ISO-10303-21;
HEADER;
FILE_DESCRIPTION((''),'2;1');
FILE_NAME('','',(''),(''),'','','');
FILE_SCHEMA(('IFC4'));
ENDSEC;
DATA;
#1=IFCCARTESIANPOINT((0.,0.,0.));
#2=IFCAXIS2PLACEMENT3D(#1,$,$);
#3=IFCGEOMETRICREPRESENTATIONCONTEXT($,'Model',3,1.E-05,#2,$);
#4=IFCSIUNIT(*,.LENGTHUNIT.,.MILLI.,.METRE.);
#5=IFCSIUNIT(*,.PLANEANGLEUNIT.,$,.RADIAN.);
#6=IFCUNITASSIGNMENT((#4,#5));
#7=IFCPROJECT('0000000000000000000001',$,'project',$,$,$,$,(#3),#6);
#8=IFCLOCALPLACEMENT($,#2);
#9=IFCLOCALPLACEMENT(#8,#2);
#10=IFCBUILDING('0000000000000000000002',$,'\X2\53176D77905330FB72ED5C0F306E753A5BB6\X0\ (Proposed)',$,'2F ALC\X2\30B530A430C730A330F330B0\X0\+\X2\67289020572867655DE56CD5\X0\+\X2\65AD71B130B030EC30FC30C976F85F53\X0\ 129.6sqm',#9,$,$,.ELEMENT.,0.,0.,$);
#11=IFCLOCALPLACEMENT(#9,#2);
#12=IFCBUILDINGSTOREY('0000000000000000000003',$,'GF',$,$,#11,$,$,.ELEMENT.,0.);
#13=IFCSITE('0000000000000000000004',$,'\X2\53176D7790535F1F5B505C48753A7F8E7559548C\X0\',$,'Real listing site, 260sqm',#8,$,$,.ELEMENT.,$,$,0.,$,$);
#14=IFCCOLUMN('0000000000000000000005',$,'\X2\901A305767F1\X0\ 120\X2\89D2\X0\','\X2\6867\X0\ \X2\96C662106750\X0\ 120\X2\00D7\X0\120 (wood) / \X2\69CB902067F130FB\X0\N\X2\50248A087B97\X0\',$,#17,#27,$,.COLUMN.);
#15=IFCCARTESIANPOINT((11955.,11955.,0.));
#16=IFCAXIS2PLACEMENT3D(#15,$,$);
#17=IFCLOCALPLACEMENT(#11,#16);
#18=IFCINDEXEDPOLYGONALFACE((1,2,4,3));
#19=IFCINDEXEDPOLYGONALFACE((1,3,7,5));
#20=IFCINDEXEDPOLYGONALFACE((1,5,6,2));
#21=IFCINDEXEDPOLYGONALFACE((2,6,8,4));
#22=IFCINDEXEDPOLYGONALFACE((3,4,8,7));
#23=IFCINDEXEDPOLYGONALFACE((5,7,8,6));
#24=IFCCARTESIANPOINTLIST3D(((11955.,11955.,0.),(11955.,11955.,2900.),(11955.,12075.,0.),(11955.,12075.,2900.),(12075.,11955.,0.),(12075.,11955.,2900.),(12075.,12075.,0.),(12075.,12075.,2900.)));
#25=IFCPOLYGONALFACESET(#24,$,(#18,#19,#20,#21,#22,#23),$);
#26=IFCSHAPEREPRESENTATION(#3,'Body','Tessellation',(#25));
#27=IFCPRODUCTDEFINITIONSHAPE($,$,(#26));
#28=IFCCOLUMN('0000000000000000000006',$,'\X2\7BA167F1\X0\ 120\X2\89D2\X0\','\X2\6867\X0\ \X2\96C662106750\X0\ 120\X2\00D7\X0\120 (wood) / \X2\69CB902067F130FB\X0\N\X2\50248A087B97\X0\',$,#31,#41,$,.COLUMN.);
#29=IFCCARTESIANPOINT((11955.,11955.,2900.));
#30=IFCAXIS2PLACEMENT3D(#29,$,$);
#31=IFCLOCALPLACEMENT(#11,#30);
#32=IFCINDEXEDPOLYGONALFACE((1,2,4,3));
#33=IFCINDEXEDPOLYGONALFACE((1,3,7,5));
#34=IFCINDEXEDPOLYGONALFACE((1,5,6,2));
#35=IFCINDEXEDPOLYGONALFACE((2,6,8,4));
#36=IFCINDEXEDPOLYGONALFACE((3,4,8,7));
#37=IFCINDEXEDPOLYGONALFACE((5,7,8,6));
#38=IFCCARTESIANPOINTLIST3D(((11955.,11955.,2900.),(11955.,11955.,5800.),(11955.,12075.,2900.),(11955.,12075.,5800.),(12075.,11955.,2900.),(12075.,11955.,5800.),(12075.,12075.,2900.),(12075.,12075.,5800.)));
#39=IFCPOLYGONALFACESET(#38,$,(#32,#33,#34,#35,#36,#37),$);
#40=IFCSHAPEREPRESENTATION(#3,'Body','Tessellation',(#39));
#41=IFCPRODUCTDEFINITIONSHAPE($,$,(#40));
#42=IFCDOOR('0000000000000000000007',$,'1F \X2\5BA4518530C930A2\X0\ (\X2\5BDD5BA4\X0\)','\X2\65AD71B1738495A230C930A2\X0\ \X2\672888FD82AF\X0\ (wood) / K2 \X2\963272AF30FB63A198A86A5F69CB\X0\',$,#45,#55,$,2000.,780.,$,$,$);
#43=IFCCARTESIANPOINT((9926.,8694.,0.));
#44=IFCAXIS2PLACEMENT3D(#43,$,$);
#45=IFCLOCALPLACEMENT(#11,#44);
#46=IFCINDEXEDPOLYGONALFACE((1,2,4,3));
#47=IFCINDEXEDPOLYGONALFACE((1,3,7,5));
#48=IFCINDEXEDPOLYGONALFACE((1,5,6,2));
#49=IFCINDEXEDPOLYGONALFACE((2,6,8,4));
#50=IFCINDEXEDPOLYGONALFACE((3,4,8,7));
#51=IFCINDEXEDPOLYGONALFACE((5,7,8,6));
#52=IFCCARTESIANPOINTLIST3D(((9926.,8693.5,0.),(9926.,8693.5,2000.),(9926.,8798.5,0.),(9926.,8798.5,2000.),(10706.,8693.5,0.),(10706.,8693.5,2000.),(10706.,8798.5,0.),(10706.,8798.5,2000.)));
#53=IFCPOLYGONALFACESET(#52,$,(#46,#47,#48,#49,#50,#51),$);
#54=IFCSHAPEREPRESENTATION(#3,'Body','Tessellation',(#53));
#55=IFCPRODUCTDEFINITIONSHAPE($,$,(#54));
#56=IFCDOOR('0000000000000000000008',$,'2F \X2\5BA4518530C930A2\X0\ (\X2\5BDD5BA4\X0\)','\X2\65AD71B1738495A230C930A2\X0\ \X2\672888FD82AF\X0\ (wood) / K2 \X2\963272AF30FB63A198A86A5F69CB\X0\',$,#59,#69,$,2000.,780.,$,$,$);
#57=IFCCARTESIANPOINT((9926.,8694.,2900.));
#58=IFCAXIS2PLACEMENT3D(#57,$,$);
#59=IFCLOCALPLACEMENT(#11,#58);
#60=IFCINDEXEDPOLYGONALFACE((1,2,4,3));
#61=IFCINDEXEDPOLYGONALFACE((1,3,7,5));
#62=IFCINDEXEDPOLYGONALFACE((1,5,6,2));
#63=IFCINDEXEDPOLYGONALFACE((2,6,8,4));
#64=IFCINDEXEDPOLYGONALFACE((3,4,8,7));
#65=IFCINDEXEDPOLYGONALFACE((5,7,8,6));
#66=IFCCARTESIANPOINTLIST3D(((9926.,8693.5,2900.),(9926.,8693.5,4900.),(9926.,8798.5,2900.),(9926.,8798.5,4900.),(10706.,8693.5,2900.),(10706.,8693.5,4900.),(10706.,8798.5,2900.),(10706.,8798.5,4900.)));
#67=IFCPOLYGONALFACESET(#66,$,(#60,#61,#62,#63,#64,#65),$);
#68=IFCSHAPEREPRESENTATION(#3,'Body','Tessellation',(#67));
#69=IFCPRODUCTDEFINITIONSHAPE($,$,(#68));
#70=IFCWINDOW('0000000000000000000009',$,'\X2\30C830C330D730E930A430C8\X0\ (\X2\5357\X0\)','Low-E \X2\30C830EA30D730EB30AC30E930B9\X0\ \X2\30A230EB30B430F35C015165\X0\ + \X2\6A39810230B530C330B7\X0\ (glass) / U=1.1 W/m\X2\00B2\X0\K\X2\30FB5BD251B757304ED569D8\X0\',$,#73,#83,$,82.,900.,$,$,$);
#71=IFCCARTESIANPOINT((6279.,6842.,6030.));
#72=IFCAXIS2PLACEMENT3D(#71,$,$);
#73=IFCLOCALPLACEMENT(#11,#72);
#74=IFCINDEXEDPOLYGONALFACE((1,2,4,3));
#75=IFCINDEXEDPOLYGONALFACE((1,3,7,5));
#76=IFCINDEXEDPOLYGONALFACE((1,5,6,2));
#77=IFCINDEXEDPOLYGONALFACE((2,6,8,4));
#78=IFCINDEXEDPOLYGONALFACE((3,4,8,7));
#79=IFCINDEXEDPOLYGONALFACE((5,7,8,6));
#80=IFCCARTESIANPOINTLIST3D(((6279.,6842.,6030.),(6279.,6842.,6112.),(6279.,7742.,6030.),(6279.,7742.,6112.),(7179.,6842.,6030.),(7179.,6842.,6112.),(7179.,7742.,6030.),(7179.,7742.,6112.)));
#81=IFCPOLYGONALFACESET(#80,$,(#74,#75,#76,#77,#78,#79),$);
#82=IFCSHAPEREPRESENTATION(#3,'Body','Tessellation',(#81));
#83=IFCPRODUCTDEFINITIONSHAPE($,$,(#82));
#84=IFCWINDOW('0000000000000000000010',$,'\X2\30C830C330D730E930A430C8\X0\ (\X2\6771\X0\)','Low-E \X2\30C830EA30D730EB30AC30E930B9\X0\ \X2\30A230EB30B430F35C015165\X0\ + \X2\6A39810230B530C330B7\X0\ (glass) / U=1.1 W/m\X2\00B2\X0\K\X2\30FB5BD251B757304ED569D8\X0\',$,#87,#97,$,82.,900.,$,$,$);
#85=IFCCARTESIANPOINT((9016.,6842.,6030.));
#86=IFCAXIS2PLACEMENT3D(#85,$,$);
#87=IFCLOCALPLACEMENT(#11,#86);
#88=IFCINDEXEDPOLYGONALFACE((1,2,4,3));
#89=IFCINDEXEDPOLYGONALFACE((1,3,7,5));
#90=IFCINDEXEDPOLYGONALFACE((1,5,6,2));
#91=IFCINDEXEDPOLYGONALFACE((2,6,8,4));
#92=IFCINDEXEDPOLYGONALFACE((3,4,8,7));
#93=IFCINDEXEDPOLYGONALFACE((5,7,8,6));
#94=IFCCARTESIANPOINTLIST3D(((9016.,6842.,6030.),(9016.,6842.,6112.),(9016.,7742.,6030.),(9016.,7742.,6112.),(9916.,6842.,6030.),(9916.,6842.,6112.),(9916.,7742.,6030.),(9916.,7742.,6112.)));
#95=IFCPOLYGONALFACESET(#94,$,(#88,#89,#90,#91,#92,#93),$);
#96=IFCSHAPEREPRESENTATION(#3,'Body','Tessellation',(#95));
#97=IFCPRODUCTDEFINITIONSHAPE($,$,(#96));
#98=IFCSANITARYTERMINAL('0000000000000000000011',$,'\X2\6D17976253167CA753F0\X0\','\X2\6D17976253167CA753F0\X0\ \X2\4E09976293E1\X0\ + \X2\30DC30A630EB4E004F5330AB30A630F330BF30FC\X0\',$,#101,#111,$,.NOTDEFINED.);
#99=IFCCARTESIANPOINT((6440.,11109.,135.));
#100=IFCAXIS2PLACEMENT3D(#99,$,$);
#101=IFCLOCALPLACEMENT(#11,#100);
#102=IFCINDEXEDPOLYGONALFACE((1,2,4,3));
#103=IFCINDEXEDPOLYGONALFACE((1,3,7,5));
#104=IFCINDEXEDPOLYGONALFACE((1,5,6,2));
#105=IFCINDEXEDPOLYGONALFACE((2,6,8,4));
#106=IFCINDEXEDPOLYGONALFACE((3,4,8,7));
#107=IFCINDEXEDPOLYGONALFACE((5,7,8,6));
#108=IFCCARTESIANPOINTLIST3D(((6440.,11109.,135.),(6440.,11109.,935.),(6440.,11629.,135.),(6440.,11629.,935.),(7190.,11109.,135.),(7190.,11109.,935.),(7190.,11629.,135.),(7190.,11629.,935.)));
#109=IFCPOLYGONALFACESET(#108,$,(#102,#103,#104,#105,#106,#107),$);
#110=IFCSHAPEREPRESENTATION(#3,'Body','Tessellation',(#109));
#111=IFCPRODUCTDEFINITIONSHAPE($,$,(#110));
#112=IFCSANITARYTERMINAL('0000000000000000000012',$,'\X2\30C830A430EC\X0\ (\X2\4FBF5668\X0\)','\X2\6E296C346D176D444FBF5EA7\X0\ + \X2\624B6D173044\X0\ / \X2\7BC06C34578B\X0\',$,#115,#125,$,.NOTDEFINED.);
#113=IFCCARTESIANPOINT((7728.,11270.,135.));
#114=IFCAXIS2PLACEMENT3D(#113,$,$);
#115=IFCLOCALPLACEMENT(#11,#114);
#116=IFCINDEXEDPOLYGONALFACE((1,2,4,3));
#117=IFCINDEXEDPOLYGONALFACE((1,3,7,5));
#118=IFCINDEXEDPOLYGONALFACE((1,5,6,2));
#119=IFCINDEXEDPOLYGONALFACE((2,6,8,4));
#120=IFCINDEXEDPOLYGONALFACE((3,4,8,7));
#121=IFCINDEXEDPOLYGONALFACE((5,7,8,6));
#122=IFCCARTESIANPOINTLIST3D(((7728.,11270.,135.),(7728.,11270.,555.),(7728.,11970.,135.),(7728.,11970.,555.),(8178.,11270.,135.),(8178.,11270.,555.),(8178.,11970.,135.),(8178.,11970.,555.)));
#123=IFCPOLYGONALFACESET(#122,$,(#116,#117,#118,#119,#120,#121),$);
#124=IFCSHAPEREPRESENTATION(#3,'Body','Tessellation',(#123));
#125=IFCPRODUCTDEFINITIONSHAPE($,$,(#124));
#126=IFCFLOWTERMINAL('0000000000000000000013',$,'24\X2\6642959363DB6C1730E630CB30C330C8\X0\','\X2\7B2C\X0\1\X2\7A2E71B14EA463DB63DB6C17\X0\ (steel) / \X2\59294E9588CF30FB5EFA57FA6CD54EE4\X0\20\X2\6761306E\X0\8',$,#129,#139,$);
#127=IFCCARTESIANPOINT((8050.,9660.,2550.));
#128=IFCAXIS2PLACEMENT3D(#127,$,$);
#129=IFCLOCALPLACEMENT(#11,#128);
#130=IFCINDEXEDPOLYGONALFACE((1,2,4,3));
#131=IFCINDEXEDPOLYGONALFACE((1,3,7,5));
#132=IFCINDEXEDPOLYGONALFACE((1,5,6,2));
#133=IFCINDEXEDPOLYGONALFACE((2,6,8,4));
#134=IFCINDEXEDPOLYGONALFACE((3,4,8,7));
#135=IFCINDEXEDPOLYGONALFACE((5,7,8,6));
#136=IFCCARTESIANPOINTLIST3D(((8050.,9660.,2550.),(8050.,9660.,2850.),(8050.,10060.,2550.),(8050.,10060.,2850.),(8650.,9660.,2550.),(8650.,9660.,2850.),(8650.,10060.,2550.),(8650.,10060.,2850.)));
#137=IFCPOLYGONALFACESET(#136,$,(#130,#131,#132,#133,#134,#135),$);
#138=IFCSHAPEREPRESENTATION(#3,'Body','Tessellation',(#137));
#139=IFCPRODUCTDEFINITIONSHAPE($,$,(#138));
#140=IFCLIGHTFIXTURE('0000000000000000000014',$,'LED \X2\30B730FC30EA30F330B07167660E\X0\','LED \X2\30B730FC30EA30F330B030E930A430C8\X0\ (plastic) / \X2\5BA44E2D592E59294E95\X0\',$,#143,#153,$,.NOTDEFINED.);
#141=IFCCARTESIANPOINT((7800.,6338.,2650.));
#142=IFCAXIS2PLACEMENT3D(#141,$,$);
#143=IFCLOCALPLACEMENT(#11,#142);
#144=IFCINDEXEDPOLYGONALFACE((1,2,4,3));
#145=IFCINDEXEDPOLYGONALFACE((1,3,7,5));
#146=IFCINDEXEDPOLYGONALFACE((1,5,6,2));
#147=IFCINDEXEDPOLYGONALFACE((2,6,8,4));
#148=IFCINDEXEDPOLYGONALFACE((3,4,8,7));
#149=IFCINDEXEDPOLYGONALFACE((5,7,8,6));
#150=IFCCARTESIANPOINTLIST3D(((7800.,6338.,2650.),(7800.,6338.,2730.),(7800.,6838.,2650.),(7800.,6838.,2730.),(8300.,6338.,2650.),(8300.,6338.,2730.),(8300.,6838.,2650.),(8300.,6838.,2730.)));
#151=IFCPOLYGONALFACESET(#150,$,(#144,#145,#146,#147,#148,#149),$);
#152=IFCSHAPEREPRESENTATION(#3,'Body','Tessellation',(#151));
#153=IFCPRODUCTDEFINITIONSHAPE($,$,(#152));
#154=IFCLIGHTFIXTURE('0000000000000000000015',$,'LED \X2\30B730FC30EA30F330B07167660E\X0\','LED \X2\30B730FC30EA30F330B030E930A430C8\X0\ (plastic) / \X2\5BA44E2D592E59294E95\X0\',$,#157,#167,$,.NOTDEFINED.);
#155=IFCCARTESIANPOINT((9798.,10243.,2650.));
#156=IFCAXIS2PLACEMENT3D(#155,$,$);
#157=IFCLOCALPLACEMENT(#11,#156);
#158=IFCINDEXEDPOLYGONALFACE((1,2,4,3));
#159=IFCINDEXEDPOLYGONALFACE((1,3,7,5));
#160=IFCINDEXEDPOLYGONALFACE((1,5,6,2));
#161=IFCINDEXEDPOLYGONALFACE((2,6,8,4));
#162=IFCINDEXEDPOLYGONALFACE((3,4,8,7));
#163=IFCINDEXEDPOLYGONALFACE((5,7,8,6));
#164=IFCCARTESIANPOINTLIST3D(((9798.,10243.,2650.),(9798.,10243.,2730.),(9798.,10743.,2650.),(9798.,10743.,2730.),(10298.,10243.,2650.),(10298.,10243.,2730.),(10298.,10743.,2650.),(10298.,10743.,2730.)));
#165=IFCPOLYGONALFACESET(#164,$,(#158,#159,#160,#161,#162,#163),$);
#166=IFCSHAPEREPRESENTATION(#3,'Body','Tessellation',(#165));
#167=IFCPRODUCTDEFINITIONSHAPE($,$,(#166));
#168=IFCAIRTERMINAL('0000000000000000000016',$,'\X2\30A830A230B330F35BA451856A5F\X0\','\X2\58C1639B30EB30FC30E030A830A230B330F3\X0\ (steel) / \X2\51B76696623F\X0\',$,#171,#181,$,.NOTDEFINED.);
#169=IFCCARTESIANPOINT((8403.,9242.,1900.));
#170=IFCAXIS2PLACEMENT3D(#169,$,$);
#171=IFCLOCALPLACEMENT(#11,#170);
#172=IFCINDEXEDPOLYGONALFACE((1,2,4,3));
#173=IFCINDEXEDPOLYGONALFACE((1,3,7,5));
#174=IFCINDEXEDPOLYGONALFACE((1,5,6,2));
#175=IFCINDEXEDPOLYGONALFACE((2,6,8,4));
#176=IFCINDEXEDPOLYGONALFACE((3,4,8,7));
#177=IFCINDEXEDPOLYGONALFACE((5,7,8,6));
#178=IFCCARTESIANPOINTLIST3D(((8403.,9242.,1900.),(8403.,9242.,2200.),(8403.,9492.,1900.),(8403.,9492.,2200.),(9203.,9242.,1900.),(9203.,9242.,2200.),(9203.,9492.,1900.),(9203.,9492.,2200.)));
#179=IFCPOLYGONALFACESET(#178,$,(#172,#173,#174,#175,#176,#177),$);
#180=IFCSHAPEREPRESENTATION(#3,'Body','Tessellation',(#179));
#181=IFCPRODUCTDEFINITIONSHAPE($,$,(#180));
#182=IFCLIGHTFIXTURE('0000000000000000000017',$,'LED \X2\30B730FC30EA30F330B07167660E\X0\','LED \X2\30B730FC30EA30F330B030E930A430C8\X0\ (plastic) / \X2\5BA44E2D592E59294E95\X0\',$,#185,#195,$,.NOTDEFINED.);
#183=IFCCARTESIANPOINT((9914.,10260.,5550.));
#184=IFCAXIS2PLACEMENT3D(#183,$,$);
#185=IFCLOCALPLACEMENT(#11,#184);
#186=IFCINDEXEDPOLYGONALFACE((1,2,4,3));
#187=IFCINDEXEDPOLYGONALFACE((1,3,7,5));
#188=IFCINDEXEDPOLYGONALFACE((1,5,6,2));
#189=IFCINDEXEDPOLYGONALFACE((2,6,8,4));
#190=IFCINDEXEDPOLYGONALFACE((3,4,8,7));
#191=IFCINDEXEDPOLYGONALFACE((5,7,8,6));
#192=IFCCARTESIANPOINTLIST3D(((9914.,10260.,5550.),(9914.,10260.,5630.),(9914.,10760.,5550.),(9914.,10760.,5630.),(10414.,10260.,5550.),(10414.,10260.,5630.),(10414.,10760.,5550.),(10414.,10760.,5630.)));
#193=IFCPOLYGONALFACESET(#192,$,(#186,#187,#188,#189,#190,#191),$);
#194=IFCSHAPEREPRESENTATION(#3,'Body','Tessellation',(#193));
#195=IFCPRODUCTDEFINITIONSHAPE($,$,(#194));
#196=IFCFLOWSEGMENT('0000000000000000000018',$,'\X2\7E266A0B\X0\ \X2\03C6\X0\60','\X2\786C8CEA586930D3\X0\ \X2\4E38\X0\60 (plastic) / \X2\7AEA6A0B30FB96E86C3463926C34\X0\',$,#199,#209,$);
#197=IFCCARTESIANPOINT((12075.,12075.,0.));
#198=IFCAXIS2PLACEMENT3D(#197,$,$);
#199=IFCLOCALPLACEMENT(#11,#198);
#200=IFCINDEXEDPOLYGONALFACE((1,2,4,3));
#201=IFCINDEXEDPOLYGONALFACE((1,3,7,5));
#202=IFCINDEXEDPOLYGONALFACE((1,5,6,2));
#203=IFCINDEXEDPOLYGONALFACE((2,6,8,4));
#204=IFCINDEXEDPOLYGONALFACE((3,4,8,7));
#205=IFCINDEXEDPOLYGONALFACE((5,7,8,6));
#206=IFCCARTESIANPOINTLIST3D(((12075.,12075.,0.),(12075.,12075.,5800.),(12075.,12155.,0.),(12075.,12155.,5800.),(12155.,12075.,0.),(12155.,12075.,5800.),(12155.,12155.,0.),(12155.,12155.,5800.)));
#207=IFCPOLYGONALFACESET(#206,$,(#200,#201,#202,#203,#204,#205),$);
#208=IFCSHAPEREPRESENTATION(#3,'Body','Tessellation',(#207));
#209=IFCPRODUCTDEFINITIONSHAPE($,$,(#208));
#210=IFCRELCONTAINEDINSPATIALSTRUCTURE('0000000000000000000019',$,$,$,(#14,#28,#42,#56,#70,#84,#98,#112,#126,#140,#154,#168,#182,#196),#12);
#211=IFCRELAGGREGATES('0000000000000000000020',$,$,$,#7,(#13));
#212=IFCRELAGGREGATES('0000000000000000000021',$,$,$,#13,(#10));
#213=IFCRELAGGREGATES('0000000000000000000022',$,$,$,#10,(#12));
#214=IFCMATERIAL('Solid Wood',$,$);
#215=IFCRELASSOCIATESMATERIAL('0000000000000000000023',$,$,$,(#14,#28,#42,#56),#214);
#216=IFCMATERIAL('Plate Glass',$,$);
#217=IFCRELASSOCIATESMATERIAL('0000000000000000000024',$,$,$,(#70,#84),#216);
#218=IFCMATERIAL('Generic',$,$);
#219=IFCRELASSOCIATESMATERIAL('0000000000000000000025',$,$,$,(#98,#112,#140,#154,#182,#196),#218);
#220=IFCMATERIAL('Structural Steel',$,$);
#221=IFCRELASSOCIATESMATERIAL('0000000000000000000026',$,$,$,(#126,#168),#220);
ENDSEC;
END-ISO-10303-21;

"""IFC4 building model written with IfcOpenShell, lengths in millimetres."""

from ifc_helpers import new_model, si_unit, frame, frame_2d, origin, place, context, project, spatial, rectangle, extrude, material, element, save


model = new_model("IFC4")

# Units and contexts
model_context = context("Model", 3, precision=1e-05, world=origin())
ifc_project = project(units=[si_unit("LENGTHUNIT", "METRE", prefix="MILLI"), si_unit("PLANEANGLEUNIT", "RADIAN")], contexts=[model_context])

# Site, building, storey
site_placement = place(None, origin())
site = spatial("IfcSite", under=ifc_project, at=site_placement, Name="北海道弟子屈町美留和", ObjectType="Real listing site, 260sqm", CompositionType="ELEMENT", RefElevation=0.0)
building_placement = place(site_placement, origin())
building = spatial("IfcBuilding", under=site, at=building_placement, Name="北海道・狭小の町家 (Proposed)", ObjectType="2F ALCサイディング+木造在来工法+断熱グレード相当 129.6sqm", CompositionType="ELEMENT", ElevationOfRefHeight=0.0, ElevationOfTerrain=0.0)
storey_placement = place(building_placement, origin())
storey = spatial("IfcBuildingStorey", under=building, at=storey_placement, Name="GF", CompositionType="ELEMENT", Elevation=0.0)

# Columns
ifc_material_1 = material(Name="Solid Wood")
column_1_placement = place(storey_placement, frame((11955.0, 11955.0, 0.0)))
element("IfcColumn", 1, at=column_1_placement, inside=storey, material=ifc_material_1, Name="通し柱 120角", Description="桧 集成材 120×120 (wood) / 構造柱・N値計算", PredefinedType="COLUMN", context=model_context, shape_type="SweptSolid", body=[
    extrude(rectangle(XDim=120.0, YDim=120.0, at=frame_2d((60.0, 60.0))), frame((11955.0, 11955.0, 0.0)), (0.0, 0.0, 1.0), 2900.0),
])
column_2_placement = place(storey_placement, frame((11955.0, 11955.0, 2900.0)))
element("IfcColumn", 2, at=column_2_placement, inside=storey, material=ifc_material_1, Name="管柱 120角", Description="桧 集成材 120×120 (wood) / 構造柱・N値計算", PredefinedType="COLUMN", context=model_context, shape_type="SweptSolid", body=[
    extrude(rectangle(XDim=120.0, YDim=120.0, at=frame_2d((60.0, 60.0))), frame((11955.0, 11955.0, 2900.0)), (0.0, 0.0, 1.0), 2900.0),
])

# Door
door_1_placement = place(storey_placement, frame((9926.0, 8694.0, 0.0)))
element("IfcDoor", 3, at=door_1_placement, inside=storey, material=ifc_material_1, Name="1F 室内ドア (寝室)", Description="断熱玄関ドア 木製芯 (wood) / K2 防犯・採風機構", OverallHeight=2000.0, OverallWidth=780.0, context=model_context, shape_type="SweptSolid", body=[
    extrude(rectangle(XDim=780.0, YDim=105.0, at=frame_2d((390.0, 52.0))), frame((9926.0, 8694.0, 0.0)), (0.0, 0.0, 1.0), 2000.0),
])

# Door
door_2_placement = place(storey_placement, frame((9926.0, 8694.0, 2900.0)))
element("IfcDoor", 4, at=door_2_placement, inside=storey, material=ifc_material_1, Name="2F 室内ドア (寝室)", Description="断熱玄関ドア 木製芯 (wood) / K2 防犯・採風機構", OverallHeight=2000.0, OverallWidth=780.0, context=model_context, shape_type="SweptSolid", body=[
    extrude(rectangle(XDim=780.0, YDim=105.0, at=frame_2d((390.0, 52.0))), frame((9926.0, 8694.0, 2900.0)), (0.0, 0.0, 1.0), 2000.0),
])

# Windows
ifc_material_2 = material(Name="Plate Glass")
window_1_placement = place(storey_placement, frame((6279.0, 6842.0, 6030.0)))
element("IfcWindow", 5, at=window_1_placement, inside=storey, material=ifc_material_2, Name="トップライト (南)", Description="Low-E トリプルガラス アルゴン封入 + 樹脂サッシ (glass) / U=1.1 W/m²K・寒冷地仕様", OverallHeight=82.0, OverallWidth=900.0, context=model_context, shape_type="SweptSolid", body=[
    extrude(rectangle(XDim=900.0, YDim=900.0, at=frame_2d((450.0, 450.0))), frame((6279.0, 6842.0, 6030.0)), (0.0, 0.0, 1.0), 82.0),
])
window_2_placement = place(storey_placement, frame((9016.0, 6842.0, 6030.0)))
element("IfcWindow", 6, at=window_2_placement, inside=storey, material=ifc_material_2, Name="トップライト (東)", Description="Low-E トリプルガラス アルゴン封入 + 樹脂サッシ (glass) / U=1.1 W/m²K・寒冷地仕様", OverallHeight=82.0, OverallWidth=900.0, context=model_context, shape_type="SweptSolid", body=[
    extrude(rectangle(XDim=900.0, YDim=900.0, at=frame_2d((450.0, 450.0))), frame((9016.0, 6842.0, 6030.0)), (0.0, 0.0, 1.0), 82.0),
])

# Sanitary terminals
ifc_material_3 = material(Name="Generic")
sanitary_terminal_1_placement = place(storey_placement, frame((6440.0, 11109.0, 135.0)))
element("IfcSanitaryTerminal", 7, at=sanitary_terminal_1_placement, inside=storey, material=ifc_material_3, Name="洗面化粧台", Description="洗面化粧台 三面鏡 + ボウル一体カウンター", PredefinedType="NOTDEFINED", context=model_context, shape_type="SweptSolid", body=[
    extrude(rectangle(XDim=750.0, YDim=520.0, at=frame_2d((375.0, 260.0))), frame((6440.0, 11109.0, 135.0)), (0.0, 0.0, 1.0), 800.0),
])
sanitary_terminal_2_placement = place(storey_placement, frame((7728.0, 11270.0, 135.0)))
element("IfcSanitaryTerminal", 8, at=sanitary_terminal_2_placement, inside=storey, material=ifc_material_3, Name="トイレ (便器)", Description="温水洗浄便座 + 手洗い / 節水型", PredefinedType="NOTDEFINED", context=model_context, shape_type="SweptSolid", body=[
    extrude(rectangle(XDim=450.0, YDim=700.0, at=frame_2d((225.0, 350.0))), frame((7728.0, 11270.0, 135.0)), (0.0, 0.0, 1.0), 420.0),
])

# Flow terminal
ifc_material_4 = material(Name="Structural Steel")
flow_terminal_placement = place(storey_placement, frame((8050.0, 9660.0, 2550.0)))
element("IfcFlowTerminal", 9, at=flow_terminal_placement, inside=storey, material=ifc_material_4, Name="24時間換気ユニット", Description="第1種熱交換換気 (steel) / 天井裏・建基法令20条の8", context=model_context, shape_type="SweptSolid", body=[
    extrude(rectangle(XDim=600.0, YDim=400.0, at=frame_2d((300.0, 200.0))), frame((8050.0, 9660.0, 2550.0)), (0.0, 0.0, 1.0), 300.0),
])

# Light fixtures
light_fixture_1_placement = place(storey_placement, frame((7800.0, 6338.0, 2650.0)))
element("IfcLightFixture", 10, at=light_fixture_1_placement, inside=storey, material=ifc_material_3, Name="LED シーリング照明", Description="LED シーリングライト (plastic) / 室中央天井", PredefinedType="NOTDEFINED", context=model_context, shape_type="SweptSolid", body=[
    extrude(rectangle(XDim=500.0, YDim=500.0, at=frame_2d((250.0, 250.0))), frame((7800.0, 6338.0, 2650.0)), (0.0, 0.0, 1.0), 80.0),
])
light_fixture_2_placement = place(storey_placement, frame((9798.0, 10243.0, 2650.0)))
element("IfcLightFixture", 11, at=light_fixture_2_placement, inside=storey, material=ifc_material_3, Name="LED シーリング照明", Description="LED シーリングライト (plastic) / 室中央天井", PredefinedType="NOTDEFINED", context=model_context, shape_type="SweptSolid", body=[
    extrude(rectangle(XDim=500.0, YDim=500.0, at=frame_2d((250.0, 250.0))), frame((9798.0, 10243.0, 2650.0)), (0.0, 0.0, 1.0), 80.0),
])

# Air terminal
air_terminal_placement = place(storey_placement, frame((8403.0, 9242.0, 1900.0)))
element("IfcAirTerminal", 12, at=air_terminal_placement, inside=storey, material=ifc_material_4, Name="エアコン室内機", Description="壁掛ルームエアコン (steel) / 冷暖房", PredefinedType="NOTDEFINED", context=model_context, shape_type="SweptSolid", body=[
    extrude(rectangle(XDim=800.0, YDim=250.0, at=frame_2d((400.0, 125.0))), frame((8403.0, 9242.0, 1900.0)), (0.0, 0.0, 1.0), 300.0),
])

# Light fixture
light_fixture_3_placement = place(storey_placement, frame((9914.0, 10260.0, 5550.0)))
element("IfcLightFixture", 13, at=light_fixture_3_placement, inside=storey, material=ifc_material_3, Name="LED シーリング照明", Description="LED シーリングライト (plastic) / 室中央天井", PredefinedType="NOTDEFINED", context=model_context, shape_type="SweptSolid", body=[
    extrude(rectangle(XDim=500.0, YDim=500.0, at=frame_2d((250.0, 250.0))), frame((9914.0, 10260.0, 5550.0)), (0.0, 0.0, 1.0), 80.0),
])

# Flow segment
flow_segment_placement = place(storey_placement, frame((12075.0, 12075.0, 0.0)))
element("IfcFlowSegment", 14, at=flow_segment_placement, inside=storey, material=ifc_material_3, Name="縦樋 φ60", Description="硬質塩ビ 丸60 (plastic) / 竪樋・雨水排水", context=model_context, shape_type="SweptSolid", body=[
    extrude(rectangle(XDim=80.0, YDim=80.0, at=frame_2d((40.0, 40.0))), frame((12075.0, 12075.0, 0.0)), (0.0, 0.0, 1.0), 5800.0),
])

save(model, "model.ifc")
